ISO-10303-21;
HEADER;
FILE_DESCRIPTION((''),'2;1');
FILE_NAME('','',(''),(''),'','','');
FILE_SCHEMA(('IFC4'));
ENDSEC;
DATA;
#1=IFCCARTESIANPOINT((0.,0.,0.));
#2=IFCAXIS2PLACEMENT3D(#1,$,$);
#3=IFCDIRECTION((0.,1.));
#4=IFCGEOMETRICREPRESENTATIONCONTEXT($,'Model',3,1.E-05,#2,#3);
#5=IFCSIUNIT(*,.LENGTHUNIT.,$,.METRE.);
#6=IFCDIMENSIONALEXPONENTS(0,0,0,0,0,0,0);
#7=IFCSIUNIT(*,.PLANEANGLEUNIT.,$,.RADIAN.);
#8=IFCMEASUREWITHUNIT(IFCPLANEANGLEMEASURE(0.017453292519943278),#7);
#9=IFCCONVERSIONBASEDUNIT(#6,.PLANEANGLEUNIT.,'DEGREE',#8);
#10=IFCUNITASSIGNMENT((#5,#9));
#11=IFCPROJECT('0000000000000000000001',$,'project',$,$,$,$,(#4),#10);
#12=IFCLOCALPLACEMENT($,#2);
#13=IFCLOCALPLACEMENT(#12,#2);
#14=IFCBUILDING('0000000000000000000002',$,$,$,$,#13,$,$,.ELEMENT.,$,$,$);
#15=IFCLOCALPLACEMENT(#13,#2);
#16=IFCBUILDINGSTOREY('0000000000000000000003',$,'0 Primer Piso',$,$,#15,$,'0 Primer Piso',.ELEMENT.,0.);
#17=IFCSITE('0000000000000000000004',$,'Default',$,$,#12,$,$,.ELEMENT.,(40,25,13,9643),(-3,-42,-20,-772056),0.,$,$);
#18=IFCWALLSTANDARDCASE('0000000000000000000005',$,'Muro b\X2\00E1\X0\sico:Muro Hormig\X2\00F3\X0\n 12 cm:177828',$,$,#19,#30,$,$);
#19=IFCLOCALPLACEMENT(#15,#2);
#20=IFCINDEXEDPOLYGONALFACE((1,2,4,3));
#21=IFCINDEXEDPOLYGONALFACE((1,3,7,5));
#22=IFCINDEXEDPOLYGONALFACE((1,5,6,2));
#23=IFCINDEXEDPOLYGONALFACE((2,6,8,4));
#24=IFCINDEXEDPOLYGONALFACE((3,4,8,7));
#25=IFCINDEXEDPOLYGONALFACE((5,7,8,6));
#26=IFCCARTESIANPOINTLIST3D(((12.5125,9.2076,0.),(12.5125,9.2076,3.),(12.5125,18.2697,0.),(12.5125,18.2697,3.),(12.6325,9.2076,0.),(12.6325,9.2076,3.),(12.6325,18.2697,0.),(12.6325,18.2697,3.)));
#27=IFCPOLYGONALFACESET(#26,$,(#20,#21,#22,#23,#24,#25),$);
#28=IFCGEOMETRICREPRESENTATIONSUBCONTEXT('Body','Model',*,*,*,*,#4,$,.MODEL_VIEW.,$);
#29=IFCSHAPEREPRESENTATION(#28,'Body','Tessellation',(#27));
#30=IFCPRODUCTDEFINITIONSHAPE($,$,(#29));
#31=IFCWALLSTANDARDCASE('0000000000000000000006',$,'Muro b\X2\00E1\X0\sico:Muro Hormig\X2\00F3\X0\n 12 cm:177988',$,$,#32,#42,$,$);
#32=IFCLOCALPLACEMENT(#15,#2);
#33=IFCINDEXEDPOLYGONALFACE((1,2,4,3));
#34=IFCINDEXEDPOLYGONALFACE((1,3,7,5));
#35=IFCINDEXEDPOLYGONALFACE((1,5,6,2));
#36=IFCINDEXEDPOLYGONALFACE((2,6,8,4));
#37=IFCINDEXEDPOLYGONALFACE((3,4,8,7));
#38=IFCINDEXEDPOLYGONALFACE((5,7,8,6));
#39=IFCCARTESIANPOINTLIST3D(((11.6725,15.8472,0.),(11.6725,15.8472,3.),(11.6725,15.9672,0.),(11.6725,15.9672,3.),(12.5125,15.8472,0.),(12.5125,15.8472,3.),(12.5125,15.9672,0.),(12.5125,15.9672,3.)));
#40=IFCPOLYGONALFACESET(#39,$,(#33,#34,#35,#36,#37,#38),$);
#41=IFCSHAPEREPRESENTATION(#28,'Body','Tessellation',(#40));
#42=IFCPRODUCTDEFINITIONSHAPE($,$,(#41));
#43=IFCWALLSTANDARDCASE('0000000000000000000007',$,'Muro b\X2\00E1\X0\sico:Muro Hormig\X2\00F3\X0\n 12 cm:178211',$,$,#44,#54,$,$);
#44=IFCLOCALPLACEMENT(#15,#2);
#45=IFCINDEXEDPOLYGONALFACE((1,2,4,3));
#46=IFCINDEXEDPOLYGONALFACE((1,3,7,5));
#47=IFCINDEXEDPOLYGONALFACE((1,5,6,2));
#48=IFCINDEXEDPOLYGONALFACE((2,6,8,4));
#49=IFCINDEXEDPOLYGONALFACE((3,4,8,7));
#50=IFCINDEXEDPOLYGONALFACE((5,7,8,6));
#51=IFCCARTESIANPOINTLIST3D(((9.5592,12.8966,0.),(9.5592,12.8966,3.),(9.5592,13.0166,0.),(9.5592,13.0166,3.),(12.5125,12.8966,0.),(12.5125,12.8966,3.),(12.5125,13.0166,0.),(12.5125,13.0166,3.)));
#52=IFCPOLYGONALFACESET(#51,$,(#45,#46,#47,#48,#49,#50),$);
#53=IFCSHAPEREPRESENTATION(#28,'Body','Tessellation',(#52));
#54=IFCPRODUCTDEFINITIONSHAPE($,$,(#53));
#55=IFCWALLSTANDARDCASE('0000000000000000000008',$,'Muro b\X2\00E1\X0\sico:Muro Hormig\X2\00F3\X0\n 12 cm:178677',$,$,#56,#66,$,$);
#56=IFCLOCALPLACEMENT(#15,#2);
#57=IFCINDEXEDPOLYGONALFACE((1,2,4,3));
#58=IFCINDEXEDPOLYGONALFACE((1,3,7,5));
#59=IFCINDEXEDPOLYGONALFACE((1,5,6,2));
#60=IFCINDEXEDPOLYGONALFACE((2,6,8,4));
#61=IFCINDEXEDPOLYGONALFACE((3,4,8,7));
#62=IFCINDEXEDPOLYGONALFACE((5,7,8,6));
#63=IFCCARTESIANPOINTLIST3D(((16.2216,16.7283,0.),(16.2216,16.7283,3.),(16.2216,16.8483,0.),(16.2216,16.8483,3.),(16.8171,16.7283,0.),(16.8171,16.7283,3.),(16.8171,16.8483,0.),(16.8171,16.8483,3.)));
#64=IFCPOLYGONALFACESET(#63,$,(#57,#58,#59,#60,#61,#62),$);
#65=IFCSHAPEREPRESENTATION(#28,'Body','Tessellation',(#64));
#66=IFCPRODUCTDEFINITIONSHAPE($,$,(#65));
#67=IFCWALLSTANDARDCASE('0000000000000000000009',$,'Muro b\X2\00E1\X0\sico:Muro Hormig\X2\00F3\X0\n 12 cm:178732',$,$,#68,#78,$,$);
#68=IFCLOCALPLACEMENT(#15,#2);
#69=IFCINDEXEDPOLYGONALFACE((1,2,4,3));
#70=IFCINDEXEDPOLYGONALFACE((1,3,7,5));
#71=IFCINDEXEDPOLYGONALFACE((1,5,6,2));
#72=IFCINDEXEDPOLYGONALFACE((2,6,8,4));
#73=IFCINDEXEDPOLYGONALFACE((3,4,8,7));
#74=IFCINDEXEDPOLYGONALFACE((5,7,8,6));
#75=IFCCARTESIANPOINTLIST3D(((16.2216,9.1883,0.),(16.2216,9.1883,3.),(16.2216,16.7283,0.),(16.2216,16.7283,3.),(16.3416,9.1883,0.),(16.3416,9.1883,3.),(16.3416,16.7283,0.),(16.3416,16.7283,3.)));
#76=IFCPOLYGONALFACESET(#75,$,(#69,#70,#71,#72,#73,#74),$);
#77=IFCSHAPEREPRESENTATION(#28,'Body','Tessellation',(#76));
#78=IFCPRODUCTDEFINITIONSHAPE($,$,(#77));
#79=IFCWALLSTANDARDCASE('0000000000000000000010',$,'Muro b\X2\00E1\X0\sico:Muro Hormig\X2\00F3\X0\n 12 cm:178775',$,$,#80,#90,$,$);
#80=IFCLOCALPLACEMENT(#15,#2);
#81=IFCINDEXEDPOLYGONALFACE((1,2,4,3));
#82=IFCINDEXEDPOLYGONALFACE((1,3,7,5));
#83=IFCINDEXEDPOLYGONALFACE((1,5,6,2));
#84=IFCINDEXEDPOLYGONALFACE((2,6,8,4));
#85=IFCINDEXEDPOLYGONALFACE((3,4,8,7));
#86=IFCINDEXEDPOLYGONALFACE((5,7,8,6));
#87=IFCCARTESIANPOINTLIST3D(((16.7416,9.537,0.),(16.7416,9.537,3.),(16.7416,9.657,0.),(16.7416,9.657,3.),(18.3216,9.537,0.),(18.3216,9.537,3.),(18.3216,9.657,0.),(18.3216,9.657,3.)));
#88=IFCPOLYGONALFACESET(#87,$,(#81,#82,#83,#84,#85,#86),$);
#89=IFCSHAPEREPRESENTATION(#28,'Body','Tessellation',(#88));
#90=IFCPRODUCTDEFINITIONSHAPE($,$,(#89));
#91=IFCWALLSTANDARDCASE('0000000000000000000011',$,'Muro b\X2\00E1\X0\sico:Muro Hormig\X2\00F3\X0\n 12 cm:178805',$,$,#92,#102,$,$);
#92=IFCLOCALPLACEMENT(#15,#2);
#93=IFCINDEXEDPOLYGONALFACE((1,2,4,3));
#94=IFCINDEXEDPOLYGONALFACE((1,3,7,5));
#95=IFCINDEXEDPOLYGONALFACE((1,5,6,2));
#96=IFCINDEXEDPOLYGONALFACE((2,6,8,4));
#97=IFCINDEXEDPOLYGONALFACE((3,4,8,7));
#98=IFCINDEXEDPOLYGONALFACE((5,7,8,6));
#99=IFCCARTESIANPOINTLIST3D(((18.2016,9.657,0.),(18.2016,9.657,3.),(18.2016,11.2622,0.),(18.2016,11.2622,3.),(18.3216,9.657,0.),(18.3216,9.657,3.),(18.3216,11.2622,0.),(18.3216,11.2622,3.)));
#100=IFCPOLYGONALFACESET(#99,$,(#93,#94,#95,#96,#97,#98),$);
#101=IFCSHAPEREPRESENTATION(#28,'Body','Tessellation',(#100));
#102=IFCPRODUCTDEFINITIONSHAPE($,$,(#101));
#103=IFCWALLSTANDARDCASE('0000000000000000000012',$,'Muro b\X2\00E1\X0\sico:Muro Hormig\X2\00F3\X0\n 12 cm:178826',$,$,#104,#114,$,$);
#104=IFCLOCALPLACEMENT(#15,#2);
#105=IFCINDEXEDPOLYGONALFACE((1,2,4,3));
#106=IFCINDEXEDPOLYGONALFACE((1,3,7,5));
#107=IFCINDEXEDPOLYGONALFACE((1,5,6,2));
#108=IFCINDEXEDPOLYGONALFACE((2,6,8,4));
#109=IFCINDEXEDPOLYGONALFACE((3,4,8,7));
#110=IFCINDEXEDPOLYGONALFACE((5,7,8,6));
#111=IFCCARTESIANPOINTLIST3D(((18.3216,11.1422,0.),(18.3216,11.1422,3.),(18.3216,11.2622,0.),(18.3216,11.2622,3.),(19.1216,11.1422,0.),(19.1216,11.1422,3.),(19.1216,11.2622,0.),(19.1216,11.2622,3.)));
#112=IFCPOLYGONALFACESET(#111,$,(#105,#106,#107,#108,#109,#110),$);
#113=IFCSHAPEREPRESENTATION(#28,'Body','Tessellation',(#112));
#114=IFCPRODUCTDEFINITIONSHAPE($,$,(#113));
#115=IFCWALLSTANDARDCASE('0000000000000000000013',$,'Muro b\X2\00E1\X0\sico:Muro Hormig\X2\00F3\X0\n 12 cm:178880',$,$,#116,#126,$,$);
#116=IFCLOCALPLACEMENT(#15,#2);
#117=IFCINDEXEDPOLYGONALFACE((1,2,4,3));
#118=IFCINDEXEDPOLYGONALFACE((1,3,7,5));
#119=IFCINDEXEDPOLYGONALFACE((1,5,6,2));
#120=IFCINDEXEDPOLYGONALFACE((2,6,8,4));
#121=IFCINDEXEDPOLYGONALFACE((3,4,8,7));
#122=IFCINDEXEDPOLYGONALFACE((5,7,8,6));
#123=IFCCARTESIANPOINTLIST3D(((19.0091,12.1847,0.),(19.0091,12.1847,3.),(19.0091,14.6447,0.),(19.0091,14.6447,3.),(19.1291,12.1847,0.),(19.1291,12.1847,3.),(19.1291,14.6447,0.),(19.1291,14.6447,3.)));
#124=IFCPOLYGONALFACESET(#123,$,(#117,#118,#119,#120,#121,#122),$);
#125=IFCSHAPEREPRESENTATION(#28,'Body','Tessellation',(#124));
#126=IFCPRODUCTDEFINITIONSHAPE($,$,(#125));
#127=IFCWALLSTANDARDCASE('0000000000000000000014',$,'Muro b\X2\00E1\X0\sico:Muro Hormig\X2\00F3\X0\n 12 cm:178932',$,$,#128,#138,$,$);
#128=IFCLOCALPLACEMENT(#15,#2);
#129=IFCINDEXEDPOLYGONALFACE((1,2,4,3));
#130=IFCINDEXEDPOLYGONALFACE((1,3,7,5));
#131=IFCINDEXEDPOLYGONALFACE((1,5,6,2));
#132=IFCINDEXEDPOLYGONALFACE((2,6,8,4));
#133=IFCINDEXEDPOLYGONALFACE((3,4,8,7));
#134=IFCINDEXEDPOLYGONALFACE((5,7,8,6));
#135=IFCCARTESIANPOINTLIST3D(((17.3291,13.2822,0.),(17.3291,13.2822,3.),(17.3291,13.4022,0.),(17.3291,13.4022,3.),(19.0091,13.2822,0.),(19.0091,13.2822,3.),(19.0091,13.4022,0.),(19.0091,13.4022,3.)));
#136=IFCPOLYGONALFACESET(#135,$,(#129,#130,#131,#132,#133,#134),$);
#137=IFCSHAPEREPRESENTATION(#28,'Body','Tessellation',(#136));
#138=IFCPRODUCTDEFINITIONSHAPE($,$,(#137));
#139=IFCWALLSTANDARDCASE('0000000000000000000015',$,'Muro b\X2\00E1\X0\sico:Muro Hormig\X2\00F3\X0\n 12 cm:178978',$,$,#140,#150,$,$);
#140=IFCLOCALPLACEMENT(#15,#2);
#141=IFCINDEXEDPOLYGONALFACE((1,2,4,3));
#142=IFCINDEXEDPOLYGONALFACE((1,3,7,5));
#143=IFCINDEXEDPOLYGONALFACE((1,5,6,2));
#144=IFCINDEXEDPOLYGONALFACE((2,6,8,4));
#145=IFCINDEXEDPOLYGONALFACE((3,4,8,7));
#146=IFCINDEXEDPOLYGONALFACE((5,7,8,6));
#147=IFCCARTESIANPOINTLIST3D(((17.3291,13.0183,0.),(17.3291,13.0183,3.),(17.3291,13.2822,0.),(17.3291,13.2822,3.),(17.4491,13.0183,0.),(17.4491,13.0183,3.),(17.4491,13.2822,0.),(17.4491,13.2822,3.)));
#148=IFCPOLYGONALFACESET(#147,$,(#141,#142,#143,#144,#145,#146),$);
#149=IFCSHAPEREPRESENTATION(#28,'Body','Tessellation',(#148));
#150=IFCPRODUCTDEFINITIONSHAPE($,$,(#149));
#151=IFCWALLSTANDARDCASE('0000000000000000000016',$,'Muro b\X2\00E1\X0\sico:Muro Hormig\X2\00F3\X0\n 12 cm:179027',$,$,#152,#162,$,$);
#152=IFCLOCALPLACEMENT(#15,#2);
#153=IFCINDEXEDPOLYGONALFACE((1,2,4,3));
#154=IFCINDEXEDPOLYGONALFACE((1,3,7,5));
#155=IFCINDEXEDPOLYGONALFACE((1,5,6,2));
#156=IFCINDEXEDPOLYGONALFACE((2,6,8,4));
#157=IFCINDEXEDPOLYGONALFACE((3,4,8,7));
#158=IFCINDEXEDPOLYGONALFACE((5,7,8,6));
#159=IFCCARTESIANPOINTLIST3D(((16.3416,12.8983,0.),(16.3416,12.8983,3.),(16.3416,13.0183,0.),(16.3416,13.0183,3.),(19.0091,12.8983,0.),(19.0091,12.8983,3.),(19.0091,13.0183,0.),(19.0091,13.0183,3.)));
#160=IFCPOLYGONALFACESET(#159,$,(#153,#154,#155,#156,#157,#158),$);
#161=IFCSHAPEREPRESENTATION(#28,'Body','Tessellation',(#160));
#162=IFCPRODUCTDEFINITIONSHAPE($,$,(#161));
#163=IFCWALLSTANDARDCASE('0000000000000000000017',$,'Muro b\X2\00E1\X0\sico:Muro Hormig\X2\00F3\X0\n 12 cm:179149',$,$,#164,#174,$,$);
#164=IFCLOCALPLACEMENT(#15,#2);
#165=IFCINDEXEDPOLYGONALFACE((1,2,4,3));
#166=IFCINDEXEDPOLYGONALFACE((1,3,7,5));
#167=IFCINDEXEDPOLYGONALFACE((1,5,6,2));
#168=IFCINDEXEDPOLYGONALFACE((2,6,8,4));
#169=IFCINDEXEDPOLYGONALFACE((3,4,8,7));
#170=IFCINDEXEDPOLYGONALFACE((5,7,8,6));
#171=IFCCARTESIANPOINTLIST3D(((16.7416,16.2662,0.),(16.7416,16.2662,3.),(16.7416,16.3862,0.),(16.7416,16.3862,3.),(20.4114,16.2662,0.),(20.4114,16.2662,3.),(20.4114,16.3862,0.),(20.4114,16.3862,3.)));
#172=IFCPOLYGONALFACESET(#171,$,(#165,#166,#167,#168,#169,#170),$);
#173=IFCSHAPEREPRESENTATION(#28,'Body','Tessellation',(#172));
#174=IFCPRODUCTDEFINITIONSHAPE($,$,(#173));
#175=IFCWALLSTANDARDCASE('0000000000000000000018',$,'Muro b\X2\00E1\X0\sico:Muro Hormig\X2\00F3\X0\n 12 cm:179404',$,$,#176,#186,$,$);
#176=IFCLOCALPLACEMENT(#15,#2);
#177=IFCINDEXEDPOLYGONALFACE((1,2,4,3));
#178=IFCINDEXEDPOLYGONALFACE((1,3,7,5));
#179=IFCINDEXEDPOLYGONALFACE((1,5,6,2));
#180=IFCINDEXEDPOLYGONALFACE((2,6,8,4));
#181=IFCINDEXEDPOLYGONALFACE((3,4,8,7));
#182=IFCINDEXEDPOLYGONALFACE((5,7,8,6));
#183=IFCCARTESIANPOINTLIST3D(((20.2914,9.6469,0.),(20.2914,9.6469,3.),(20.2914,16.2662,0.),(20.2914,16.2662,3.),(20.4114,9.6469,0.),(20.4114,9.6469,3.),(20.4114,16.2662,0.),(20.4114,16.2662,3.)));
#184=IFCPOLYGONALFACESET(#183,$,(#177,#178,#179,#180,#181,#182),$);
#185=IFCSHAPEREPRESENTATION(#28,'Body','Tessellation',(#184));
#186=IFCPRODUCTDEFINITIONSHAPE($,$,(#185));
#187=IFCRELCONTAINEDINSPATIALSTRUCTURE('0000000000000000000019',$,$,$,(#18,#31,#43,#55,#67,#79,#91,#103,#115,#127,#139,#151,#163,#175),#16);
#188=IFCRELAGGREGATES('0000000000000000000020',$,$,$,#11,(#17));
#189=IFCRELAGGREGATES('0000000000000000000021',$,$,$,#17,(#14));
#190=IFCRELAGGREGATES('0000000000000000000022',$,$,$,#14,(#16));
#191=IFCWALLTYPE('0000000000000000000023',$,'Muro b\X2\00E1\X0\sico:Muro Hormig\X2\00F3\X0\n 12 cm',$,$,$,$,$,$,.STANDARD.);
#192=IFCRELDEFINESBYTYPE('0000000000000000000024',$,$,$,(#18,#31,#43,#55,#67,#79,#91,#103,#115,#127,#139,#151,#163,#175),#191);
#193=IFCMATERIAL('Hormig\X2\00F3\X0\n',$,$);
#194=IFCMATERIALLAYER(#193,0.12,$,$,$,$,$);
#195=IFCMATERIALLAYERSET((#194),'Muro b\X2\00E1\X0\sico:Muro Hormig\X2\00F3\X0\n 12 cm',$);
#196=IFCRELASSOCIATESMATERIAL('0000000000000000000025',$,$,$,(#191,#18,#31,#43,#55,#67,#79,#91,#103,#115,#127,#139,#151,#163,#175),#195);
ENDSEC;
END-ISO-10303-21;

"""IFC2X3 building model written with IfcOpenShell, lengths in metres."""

from ifc_helpers import new_model, entity, si_unit, converted_unit, direction, frame, frame_2d, origin, place, context, subcontext, project, spatial, rectangle, extrude, material, layer, layer_set, layer_usage, type_object, element, save


model = new_model("IFC2X3")

# Units and contexts
model_context = context("Model", 3, precision=1e-05, world=origin(), true_north=direction((0.0, 1.0)))
body_context = subcontext(model_context, "Body", "Model", "MODEL_VIEW")
ifc_project = project(units=[si_unit("LENGTHUNIT", "METRE"), converted_unit("PLANEANGLEUNIT", "DEGREE", entity("IfcPlaneAngleMeasure", 0.017453292519943278), si_unit("PLANEANGLEUNIT", "RADIAN"), dimensions=[0, 0, 0, 0, 0, 0, 0])], contexts=[model_context])

# Site, building, storey
site_placement = place(None, origin())
site = spatial("IfcSite", under=ifc_project, at=site_placement, Name="Default", CompositionType="ELEMENT", RefLatitude=(40, 25, 13, 9643), RefLongitude=(-3, -42, -20, -772056), RefElevation=0.0)
building_placement = place(site_placement, origin())
building = spatial("IfcBuilding", under=site, at=building_placement, CompositionType="ELEMENT")
storey_placement = place(building_placement, origin())
storey = spatial("IfcBuildingStorey", under=building, at=storey_placement, Name="0 Primer Piso", LongName="0 Primer Piso", CompositionType="ELEMENT", Elevation=0.0)

# Walls
ifc_material = material(Name="Hormigón")
ifc_layer = layer(ifc_material, 0.12)
ifc_layer_set = layer_set([ifc_layer], Name="Muro básico:Muro Hormigón 12 cm")
ifc_layer_usage_1 = layer_usage(ifc_layer_set, "AXIS2", "NEGATIVE", 0.06)
wall_type = type_object("IfcWallType", Name="Muro básico:Muro Hormigón 12 cm", PredefinedType="STANDARD", material=ifc_layer_set)
wall_1_placement = place(storey_placement, frame((12.5725, 18.2697, 0.0), z_axis=(0.0, 0.0, 1.0), x_axis=(0.0, -1.0, 0.0)))
element("IfcWallStandardCase", 1, at=wall_1_placement, inside=storey, type_object=wall_type, material=ifc_layer_usage_1, Name="Muro básico:Muro Hormigón 12 cm:177828", context=body_context, shape_type="SweptSolid", body=[
    extrude(rectangle(XDim=9.0621, YDim=0.12, at=frame_2d((4.5311, 0.0), x_axis=(-1.0, 0.0))), origin(), (0.0, 0.0, 1.0), 3.0),
])
ifc_layer_usage_2 = layer_usage(ifc_layer_set, "AXIS2", "NEGATIVE", 0.06)
wall_2_placement = place(storey_placement, frame((12.5125, 15.9072, 0.0), z_axis=(0.0, 0.0, 1.0), x_axis=(-1.0, 0.0, 0.0)))
element("IfcWallStandardCase", 2, at=wall_2_placement, inside=storey, type_object=wall_type, material=ifc_layer_usage_2, Name="Muro básico:Muro Hormigón 12 cm:177988", context=body_context, shape_type="SweptSolid", body=[
    extrude(rectangle(XDim=0.84, YDim=0.12, at=frame_2d((0.42, 0.0), x_axis=(-1.0, 0.0))), origin(), (0.0, 0.0, 1.0), 3.0),
])
ifc_layer_usage_3 = layer_usage(ifc_layer_set, "AXIS2", "NEGATIVE", 0.06)
wall_3_placement = place(storey_placement, frame((12.5125, 12.9566, 0.0), z_axis=(0.0, 0.0, 1.0), x_axis=(-1.0, 0.0, 0.0)))
element("IfcWallStandardCase", 3, at=wall_3_placement, inside=storey, type_object=wall_type, material=ifc_layer_usage_3, Name="Muro básico:Muro Hormigón 12 cm:178211", context=body_context, shape_type="SweptSolid", body=[
    extrude(rectangle(XDim=2.9533, YDim=0.12, at=frame_2d((1.4767, 0.0), x_axis=(-1.0, 0.0))), origin(), (0.0, 0.0, 1.0), 3.0),
])
ifc_layer_usage_4 = layer_usage(ifc_layer_set, "AXIS2", "NEGATIVE", 0.06)
wall_4_placement = place(storey_placement, frame((16.8171, 16.7883, 0.0), z_axis=(0.0, 0.0, 1.0), x_axis=(-1.0, 0.0, 0.0)))
element("IfcWallStandardCase", 4, at=wall_4_placement, inside=storey, type_object=wall_type, material=ifc_layer_usage_4, Name="Muro básico:Muro Hormigón 12 cm:178677", context=body_context, shape_type="SweptSolid", body=[
    extrude(rectangle(XDim=0.5955, YDim=0.12, at=frame_2d((0.2977, 0.0), x_axis=(-1.0, 0.0))), origin(), (0.0, 0.0, 1.0), 3.0),
])
ifc_layer_usage_5 = layer_usage(ifc_layer_set, "AXIS2", "NEGATIVE", 0.06)
wall_5_placement = place(storey_placement, frame((16.2816, 16.7283, 0.0), z_axis=(0.0, 0.0, 1.0), x_axis=(0.0, -1.0, 0.0)))
element("IfcWallStandardCase", 5, at=wall_5_placement, inside=storey, type_object=wall_type, material=ifc_layer_usage_5, Name="Muro básico:Muro Hormigón 12 cm:178732", context=body_context, shape_type="SweptSolid", body=[
    extrude(rectangle(XDim=7.54, YDim=0.12, at=frame_2d((3.77, 0.0), x_axis=(-1.0, 0.0))), origin(), (0.0, 0.0, 1.0), 3.0),
])
ifc_layer_usage_6 = layer_usage(ifc_layer_set, "AXIS2", "NEGATIVE", 0.06)
wall_6_placement = place(storey_placement, frame((16.7416, 9.597, 0.0)))
element("IfcWallStandardCase", 6, at=wall_6_placement, inside=storey, type_object=wall_type, material=ifc_layer_usage_6, Name="Muro básico:Muro Hormigón 12 cm:178775", context=body_context, shape_type="SweptSolid", body=[
    extrude(rectangle(XDim=1.58, YDim=0.12, at=frame_2d((0.79, 0.0), x_axis=(-1.0, 0.0))), origin(), (0.0, 0.0, 1.0), 3.0),
])
ifc_layer_usage_7 = layer_usage(ifc_layer_set, "AXIS2", "NEGATIVE", 0.06)
wall_7_placement = place(storey_placement, frame((18.2616, 9.657, 0.0), z_axis=(0.0, 0.0, 1.0), x_axis=(0.0, 1.0, 0.0)))
element("IfcWallStandardCase", 7, at=wall_7_placement, inside=storey, type_object=wall_type, material=ifc_layer_usage_7, Name="Muro básico:Muro Hormigón 12 cm:178805", context=body_context, shape_type="SweptSolid", body=[
    extrude(rectangle(XDim=1.6051, YDim=0.12, at=frame_2d((0.8026, 0.0), x_axis=(-1.0, 0.0))), origin(), (0.0, 0.0, 1.0), 3.0),
])
ifc_layer_usage_8 = layer_usage(ifc_layer_set, "AXIS2", "NEGATIVE", 0.06)
wall_8_placement = place(storey_placement, frame((18.3216, 11.2022, 0.0)))
element("IfcWallStandardCase", 8, at=wall_8_placement, inside=storey, type_object=wall_type, material=ifc_layer_usage_8, Name="Muro básico:Muro Hormigón 12 cm:178826", context=body_context, shape_type="SweptSolid", body=[
    extrude(rectangle(XDim=0.8, YDim=0.12, at=frame_2d((0.4, 0.0), x_axis=(-1.0, 0.0))), origin(), (0.0, 0.0, 1.0), 3.0),
])
ifc_layer_usage_9 = layer_usage(ifc_layer_set, "AXIS2", "NEGATIVE", 0.06)
wall_9_placement = place(storey_placement, frame((19.0691, 12.1847, 0.0), z_axis=(0.0, 0.0, 1.0), x_axis=(0.0, 1.0, 0.0)))
element("IfcWallStandardCase", 9, at=wall_9_placement, inside=storey, type_object=wall_type, material=ifc_layer_usage_9, Name="Muro básico:Muro Hormigón 12 cm:178880", context=body_context, shape_type="SweptSolid", body=[
    extrude(rectangle(XDim=2.46, YDim=0.12, at=frame_2d((1.23, 0.0), x_axis=(-1.0, 0.0))), origin(), (0.0, 0.0, 1.0), 3.0),
])
ifc_layer_usage_10 = layer_usage(ifc_layer_set, "AXIS2", "NEGATIVE", 0.06)
wall_10_placement = place(storey_placement, frame((19.0091, 13.3422, 0.0), z_axis=(0.0, 0.0, 1.0), x_axis=(-1.0, 0.0, 0.0)))
element("IfcWallStandardCase", 10, at=wall_10_placement, inside=storey, type_object=wall_type, material=ifc_layer_usage_10, Name="Muro básico:Muro Hormigón 12 cm:178932", context=body_context, shape_type="SweptSolid", body=[
    extrude(rectangle(XDim=1.68, YDim=0.12, at=frame_2d((0.84, 0.0), x_axis=(-1.0, 0.0))), origin(), (0.0, 0.0, 1.0), 3.0),
])
ifc_layer_usage_11 = layer_usage(ifc_layer_set, "AXIS2", "NEGATIVE", 0.06)
wall_11_placement = place(storey_placement, frame((17.3891, 13.2822, 0.0), z_axis=(0.0, 0.0, 1.0), x_axis=(0.0, -1.0, 0.0)))
element("IfcWallStandardCase", 11, at=wall_11_placement, inside=storey, type_object=wall_type, material=ifc_layer_usage_11, Name="Muro básico:Muro Hormigón 12 cm:178978", context=body_context, shape_type="SweptSolid", body=[
    extrude(rectangle(XDim=0.2639, YDim=0.12, at=frame_2d((0.1319, 0.0), x_axis=(-1.0, 0.0))), origin(), (0.0, 0.0, 1.0), 3.0),
])
ifc_layer_usage_12 = layer_usage(ifc_layer_set, "AXIS2", "NEGATIVE", 0.06)
wall_12_placement = place(storey_placement, frame((16.3416, 12.9583, 0.0)))
element("IfcWallStandardCase", 12, at=wall_12_placement, inside=storey, type_object=wall_type, material=ifc_layer_usage_12, Name="Muro básico:Muro Hormigón 12 cm:179027", context=body_context, shape_type="SweptSolid", body=[
    extrude(rectangle(XDim=2.6675, YDim=0.12, at=frame_2d((1.3337, 0.0), x_axis=(-1.0, 0.0))), origin(), (0.0, 0.0, 1.0), 3.0),
])
ifc_layer_usage_13 = layer_usage(ifc_layer_set, "AXIS2", "NEGATIVE", 0.06)
wall_13_placement = place(storey_placement, frame((16.7416, 16.3262, 0.0)))
element("IfcWallStandardCase", 13, at=wall_13_placement, inside=storey, type_object=wall_type, material=ifc_layer_usage_13, Name="Muro básico:Muro Hormigón 12 cm:179149", context=body_context, shape_type="SweptSolid", body=[
    extrude(rectangle(XDim=3.6698, YDim=0.12, at=frame_2d((1.8349, 0.0), x_axis=(-1.0, 0.0))), origin(), (0.0, 0.0, 1.0), 3.0),
])
ifc_layer_usage_14 = layer_usage(ifc_layer_set, "AXIS2", "NEGATIVE", 0.06)
wall_14_placement = place(storey_placement, frame((20.3514, 9.6469, 0.0), z_axis=(0.0, 0.0, 1.0), x_axis=(0.0, 1.0, 0.0)))
element("IfcWallStandardCase", 14, at=wall_14_placement, inside=storey, type_object=wall_type, material=ifc_layer_usage_14, Name="Muro básico:Muro Hormigón 12 cm:179404", context=body_context, shape_type="SweptSolid", body=[
    extrude(rectangle(XDim=6.6193, YDim=0.12, at=frame_2d((3.3097, 0.0), x_axis=(-1.0, 0.0))), origin(), (0.0, 0.0, 1.0), 3.0),
])

save(model, "model.ifc")
